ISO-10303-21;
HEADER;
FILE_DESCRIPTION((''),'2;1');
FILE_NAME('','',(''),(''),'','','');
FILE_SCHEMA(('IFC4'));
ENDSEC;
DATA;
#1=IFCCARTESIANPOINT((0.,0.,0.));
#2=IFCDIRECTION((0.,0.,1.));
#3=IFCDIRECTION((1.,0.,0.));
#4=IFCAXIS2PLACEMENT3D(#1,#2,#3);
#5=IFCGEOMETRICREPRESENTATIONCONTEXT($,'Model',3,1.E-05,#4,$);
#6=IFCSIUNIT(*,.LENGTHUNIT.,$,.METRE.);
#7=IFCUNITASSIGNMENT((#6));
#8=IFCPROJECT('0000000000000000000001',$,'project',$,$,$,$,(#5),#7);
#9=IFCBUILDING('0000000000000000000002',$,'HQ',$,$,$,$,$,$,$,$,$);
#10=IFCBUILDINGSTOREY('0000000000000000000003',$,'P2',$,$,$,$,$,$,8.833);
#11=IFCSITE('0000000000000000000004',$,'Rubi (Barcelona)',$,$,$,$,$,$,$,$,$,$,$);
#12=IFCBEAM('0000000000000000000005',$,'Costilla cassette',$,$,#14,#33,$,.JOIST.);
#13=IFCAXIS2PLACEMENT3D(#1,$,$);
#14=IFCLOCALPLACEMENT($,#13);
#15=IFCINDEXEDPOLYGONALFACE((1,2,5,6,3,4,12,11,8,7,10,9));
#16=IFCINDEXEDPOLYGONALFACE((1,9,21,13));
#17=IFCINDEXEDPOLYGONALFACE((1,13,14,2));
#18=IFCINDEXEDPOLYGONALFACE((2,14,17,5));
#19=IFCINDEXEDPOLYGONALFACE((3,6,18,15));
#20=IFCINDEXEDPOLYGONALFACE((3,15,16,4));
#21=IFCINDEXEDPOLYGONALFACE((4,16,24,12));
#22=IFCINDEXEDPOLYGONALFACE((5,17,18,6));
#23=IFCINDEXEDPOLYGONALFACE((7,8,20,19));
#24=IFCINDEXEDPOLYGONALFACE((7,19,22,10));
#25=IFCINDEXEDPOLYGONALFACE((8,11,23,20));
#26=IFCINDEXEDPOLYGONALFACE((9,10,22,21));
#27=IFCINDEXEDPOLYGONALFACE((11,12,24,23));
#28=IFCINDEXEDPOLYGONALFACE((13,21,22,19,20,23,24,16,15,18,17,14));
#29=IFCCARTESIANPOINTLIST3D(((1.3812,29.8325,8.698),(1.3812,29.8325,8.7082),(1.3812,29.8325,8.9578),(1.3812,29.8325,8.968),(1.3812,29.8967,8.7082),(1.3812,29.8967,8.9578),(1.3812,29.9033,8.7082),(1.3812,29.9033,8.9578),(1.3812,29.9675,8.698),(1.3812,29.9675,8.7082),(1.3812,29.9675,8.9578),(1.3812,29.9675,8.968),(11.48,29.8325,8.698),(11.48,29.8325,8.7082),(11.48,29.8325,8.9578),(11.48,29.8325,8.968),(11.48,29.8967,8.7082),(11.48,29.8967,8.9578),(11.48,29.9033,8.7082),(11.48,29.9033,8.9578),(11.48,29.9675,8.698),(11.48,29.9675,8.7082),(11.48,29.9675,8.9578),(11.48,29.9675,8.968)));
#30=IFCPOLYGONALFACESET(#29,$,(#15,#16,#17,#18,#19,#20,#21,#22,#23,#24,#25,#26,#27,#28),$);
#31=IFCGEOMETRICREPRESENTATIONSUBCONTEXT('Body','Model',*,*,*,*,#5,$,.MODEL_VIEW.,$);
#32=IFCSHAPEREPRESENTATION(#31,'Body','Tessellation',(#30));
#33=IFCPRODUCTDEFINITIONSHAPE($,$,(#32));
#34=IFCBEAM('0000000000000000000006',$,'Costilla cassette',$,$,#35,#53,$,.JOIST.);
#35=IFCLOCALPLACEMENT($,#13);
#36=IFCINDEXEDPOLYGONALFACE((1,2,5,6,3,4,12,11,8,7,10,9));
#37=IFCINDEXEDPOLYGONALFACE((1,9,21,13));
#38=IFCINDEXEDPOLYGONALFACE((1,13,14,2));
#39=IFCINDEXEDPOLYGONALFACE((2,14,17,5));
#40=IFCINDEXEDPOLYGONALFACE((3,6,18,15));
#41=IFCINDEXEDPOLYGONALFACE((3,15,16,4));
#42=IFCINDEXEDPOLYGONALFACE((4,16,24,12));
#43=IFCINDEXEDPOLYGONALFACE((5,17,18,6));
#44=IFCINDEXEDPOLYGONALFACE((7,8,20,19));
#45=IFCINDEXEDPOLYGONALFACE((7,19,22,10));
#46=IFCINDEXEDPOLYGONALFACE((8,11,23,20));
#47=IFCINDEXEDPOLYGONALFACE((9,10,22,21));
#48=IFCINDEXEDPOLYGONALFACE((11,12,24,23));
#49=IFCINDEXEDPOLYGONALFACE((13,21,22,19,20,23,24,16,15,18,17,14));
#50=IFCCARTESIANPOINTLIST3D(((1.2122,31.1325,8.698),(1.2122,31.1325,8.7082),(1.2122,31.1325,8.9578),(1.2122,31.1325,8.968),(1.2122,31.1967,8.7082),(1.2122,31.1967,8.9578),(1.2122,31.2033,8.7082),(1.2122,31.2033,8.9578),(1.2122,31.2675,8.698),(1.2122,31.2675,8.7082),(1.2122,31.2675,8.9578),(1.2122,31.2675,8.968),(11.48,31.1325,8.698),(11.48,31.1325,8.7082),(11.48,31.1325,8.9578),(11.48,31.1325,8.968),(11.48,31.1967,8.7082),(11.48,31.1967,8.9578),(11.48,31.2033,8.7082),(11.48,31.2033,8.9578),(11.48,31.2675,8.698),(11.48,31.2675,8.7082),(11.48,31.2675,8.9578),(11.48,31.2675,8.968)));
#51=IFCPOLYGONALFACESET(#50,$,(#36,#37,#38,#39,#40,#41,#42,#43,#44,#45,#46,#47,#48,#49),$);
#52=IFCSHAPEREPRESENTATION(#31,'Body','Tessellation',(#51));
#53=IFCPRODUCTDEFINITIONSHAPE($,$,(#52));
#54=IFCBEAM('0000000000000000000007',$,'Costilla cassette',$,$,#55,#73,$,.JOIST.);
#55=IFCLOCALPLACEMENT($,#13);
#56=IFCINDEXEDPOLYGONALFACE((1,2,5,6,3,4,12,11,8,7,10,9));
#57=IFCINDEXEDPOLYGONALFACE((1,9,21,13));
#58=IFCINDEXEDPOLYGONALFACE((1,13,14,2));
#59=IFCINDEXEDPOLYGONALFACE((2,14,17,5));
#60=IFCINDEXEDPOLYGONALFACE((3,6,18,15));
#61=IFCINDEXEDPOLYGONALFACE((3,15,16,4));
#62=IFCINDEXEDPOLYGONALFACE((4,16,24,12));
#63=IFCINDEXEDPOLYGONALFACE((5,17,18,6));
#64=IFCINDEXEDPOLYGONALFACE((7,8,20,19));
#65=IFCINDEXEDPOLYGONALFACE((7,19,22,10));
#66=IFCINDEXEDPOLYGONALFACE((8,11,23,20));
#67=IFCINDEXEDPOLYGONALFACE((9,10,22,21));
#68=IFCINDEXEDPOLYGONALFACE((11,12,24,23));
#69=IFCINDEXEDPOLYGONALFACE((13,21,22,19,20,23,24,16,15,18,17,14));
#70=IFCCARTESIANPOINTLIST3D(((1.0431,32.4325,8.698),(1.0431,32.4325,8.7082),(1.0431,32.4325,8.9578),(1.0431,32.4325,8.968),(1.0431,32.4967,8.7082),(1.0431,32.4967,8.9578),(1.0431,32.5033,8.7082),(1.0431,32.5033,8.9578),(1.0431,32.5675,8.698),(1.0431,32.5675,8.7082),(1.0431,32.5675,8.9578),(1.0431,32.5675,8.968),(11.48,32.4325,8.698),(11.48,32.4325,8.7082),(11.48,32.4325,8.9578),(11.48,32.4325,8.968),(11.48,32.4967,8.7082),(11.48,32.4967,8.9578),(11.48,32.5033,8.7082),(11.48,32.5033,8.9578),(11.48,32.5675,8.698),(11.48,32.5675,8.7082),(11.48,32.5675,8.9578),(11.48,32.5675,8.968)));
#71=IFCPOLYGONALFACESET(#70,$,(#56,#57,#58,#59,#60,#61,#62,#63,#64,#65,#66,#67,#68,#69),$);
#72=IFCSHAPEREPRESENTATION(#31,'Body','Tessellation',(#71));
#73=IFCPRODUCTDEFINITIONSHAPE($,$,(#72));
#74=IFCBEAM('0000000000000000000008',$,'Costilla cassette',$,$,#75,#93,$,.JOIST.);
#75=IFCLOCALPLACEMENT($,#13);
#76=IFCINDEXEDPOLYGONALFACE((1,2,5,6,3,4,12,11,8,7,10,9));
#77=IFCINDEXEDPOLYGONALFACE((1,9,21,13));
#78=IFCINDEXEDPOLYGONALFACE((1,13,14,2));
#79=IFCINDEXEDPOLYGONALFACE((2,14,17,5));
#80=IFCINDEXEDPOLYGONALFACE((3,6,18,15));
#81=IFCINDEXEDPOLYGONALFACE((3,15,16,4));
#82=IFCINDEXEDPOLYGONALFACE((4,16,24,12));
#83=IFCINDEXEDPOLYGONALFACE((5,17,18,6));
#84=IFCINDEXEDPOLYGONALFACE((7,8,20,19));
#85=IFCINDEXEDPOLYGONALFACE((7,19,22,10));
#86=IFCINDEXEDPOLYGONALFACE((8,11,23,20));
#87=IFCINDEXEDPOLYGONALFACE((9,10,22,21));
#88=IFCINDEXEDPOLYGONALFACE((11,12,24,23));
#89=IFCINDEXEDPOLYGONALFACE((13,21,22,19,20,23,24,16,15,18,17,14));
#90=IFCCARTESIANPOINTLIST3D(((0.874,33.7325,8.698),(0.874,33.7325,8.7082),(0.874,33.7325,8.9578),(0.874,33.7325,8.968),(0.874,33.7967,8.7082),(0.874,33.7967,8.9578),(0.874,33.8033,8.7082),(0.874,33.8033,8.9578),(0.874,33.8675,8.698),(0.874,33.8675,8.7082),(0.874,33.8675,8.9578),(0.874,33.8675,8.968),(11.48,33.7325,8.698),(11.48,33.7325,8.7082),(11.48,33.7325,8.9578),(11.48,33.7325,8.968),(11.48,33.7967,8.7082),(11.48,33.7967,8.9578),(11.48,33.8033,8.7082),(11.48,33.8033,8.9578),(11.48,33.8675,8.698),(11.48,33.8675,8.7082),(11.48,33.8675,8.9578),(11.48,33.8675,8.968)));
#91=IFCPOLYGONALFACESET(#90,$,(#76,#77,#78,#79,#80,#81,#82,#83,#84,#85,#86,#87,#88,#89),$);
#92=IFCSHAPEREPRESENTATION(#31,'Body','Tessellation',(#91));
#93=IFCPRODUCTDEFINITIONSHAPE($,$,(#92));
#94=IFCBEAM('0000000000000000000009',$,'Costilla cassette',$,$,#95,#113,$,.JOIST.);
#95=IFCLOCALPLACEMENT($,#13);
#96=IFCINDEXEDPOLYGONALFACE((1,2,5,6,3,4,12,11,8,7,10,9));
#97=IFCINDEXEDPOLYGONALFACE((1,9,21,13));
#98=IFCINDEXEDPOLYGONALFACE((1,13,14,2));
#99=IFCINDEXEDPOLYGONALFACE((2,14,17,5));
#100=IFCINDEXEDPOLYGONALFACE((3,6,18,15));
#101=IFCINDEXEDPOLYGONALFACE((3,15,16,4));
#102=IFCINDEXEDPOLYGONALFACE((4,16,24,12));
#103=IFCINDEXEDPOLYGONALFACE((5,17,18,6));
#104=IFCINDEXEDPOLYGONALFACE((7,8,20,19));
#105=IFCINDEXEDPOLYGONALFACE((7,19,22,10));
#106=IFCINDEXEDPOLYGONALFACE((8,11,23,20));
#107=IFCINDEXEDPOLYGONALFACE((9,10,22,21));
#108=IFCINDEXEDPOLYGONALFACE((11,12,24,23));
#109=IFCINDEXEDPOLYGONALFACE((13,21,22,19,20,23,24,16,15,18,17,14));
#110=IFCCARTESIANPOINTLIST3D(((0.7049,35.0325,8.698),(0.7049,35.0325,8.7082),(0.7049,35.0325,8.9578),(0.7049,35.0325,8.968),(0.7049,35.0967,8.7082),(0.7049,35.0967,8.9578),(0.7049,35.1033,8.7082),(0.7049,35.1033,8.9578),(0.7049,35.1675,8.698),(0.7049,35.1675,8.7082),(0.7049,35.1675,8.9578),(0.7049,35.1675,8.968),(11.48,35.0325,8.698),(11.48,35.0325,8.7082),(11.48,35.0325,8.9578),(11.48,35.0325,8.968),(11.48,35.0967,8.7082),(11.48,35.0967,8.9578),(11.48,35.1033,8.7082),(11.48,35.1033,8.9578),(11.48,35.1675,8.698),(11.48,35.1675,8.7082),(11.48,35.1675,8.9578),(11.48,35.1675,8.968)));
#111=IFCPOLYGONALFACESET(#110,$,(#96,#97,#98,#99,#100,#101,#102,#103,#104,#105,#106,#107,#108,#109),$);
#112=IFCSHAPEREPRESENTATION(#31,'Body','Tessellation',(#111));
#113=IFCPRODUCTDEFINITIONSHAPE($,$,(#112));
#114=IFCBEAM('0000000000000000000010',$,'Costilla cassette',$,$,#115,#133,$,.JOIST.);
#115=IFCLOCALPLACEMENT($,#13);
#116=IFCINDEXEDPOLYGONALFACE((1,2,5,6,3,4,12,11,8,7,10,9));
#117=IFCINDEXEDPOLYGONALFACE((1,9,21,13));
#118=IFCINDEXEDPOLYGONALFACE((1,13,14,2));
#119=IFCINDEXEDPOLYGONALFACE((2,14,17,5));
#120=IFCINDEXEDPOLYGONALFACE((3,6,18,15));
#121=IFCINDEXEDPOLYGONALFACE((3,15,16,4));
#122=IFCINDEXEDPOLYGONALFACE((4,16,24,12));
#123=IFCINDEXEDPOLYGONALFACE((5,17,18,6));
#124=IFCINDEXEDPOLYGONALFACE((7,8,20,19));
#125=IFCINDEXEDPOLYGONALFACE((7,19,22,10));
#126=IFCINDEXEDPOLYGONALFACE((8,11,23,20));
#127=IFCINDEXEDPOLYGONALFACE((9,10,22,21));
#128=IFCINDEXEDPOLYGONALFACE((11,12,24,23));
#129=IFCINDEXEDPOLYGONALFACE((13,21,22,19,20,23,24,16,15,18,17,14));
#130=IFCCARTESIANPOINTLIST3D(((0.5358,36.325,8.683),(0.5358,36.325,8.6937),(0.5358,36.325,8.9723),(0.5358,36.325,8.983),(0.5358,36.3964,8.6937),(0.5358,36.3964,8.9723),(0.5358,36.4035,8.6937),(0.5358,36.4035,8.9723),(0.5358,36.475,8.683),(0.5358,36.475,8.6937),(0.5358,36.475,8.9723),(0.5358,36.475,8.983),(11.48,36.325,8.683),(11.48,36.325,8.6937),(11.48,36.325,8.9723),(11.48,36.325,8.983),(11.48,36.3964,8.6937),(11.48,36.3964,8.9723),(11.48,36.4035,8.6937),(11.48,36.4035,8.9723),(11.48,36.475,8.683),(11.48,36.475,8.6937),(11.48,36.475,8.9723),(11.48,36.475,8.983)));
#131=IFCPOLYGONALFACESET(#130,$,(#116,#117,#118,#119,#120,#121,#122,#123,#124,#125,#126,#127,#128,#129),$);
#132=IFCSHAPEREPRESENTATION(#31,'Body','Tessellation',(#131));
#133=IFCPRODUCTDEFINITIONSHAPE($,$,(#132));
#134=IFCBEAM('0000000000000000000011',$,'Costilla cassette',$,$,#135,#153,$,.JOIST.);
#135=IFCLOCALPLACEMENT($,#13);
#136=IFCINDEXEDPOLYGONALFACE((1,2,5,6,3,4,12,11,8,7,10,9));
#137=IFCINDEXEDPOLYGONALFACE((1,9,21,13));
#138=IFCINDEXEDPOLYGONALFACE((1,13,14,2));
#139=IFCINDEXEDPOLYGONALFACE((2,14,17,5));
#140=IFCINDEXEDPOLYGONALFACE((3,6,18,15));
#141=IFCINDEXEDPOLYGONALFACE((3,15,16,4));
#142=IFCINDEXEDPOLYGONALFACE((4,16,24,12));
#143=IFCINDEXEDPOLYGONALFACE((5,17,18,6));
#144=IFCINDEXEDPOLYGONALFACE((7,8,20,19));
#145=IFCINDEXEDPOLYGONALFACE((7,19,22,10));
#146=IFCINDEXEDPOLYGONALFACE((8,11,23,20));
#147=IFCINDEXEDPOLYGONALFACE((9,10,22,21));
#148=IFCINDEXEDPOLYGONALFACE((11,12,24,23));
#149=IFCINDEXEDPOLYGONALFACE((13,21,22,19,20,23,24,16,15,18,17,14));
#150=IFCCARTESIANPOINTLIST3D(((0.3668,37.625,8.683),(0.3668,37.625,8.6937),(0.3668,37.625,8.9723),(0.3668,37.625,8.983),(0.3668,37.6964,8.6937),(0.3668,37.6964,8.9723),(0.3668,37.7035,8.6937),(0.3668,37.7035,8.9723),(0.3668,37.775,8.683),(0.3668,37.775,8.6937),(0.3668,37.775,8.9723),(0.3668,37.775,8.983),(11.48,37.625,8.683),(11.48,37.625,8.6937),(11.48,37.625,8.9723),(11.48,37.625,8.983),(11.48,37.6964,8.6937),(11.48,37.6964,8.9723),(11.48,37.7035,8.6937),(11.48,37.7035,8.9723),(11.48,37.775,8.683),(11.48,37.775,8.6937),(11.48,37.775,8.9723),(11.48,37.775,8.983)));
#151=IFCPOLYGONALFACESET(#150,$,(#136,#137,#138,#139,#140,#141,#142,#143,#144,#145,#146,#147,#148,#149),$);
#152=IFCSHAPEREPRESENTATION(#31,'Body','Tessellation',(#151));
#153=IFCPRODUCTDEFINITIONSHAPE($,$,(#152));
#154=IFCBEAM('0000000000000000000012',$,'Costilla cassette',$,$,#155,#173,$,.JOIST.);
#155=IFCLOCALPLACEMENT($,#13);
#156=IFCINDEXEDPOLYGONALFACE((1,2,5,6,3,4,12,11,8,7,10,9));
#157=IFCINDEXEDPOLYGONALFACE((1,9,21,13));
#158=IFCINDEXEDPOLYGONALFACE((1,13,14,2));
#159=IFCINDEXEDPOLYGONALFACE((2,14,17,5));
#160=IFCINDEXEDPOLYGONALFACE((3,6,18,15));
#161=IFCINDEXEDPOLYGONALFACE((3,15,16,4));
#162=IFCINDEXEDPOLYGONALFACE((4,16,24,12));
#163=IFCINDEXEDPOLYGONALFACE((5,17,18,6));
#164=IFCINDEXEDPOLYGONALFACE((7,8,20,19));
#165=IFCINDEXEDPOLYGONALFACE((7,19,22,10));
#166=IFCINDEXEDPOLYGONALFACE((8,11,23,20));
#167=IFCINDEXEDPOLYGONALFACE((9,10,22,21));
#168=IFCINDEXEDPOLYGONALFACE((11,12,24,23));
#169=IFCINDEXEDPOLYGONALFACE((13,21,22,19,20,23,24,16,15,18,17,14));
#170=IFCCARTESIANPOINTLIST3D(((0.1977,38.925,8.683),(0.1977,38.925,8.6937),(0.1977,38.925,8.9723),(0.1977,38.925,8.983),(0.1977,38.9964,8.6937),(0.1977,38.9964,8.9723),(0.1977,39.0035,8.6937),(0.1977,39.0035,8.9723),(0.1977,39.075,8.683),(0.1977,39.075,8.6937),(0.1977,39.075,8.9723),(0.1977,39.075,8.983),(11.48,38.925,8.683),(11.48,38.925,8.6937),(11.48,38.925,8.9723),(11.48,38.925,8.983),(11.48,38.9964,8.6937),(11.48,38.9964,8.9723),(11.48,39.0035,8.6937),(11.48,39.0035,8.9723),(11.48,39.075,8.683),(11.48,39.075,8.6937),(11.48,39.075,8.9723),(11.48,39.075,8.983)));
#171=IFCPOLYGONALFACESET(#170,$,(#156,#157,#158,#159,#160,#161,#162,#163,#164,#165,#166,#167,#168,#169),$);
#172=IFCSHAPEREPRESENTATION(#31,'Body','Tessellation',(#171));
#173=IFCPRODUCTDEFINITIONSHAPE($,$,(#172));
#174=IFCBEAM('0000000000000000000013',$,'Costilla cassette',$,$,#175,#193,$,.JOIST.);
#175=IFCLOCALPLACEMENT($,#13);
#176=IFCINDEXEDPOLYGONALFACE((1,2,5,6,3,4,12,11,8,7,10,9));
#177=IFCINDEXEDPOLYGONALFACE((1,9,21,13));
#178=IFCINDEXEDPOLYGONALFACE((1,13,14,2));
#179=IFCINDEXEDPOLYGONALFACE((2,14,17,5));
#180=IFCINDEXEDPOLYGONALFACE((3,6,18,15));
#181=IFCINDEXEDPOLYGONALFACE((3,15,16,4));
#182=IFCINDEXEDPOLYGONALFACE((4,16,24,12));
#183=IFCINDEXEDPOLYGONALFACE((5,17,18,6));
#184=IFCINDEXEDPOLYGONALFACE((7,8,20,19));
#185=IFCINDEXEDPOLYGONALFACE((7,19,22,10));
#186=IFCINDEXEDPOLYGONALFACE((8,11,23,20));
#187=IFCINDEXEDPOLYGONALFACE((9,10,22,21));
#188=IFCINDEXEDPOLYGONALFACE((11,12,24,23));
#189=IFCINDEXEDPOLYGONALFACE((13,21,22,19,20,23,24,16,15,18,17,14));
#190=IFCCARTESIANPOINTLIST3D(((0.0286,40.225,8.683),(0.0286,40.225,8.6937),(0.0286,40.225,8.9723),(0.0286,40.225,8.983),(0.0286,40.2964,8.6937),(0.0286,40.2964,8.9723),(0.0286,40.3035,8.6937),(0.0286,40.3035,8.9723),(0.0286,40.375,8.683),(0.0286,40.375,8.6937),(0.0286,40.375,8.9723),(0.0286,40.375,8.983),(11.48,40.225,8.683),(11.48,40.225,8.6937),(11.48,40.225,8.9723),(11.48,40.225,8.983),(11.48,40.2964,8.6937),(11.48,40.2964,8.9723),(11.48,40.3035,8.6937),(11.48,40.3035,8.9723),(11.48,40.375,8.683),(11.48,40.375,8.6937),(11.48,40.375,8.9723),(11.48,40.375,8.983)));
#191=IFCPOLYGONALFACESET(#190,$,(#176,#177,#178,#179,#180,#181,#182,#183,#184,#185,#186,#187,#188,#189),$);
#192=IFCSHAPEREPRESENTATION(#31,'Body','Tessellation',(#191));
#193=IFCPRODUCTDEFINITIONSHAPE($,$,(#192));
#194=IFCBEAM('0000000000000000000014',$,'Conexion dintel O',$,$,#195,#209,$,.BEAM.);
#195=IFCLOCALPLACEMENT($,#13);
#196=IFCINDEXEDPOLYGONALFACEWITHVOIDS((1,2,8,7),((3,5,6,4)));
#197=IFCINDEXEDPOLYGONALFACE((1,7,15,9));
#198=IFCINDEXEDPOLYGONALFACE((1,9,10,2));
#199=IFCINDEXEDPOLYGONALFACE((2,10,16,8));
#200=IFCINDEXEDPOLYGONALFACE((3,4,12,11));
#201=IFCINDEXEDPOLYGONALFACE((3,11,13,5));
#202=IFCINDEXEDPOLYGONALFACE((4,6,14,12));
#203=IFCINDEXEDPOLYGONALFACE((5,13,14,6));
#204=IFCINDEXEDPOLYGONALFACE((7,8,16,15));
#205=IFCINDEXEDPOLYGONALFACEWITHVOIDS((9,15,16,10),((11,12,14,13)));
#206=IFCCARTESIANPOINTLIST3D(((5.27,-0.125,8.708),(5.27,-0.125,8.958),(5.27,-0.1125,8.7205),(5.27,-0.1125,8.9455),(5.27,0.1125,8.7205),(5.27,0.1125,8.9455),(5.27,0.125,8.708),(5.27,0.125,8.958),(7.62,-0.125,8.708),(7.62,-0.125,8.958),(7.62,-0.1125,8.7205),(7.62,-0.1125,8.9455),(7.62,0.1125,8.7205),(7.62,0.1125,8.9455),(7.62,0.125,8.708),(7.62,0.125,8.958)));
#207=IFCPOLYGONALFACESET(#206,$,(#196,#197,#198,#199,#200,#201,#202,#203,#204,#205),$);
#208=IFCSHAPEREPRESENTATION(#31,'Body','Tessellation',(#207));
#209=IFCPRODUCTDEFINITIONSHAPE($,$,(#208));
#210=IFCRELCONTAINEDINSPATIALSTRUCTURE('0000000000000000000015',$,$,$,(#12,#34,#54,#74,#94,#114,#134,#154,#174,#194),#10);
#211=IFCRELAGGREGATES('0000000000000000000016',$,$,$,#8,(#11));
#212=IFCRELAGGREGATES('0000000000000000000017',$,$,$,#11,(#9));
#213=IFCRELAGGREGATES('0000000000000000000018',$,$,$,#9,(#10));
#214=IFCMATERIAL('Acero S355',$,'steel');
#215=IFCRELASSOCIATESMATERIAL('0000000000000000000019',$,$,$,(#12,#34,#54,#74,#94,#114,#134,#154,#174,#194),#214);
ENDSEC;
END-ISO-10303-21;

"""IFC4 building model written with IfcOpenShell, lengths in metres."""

from ifc_helpers import new_model, si_unit, frame, origin_with_axes, place, context, subcontext, project, spatial, hollow_rectangle, i_section, extrude, material, element, save


model = new_model("IFC4")

# Units and contexts
model_context = context("Model", 3, precision=1e-05, world=origin_with_axes())
body_context = subcontext(model_context, "Body", "Model", "MODEL_VIEW")
ifc_project = project(units=[si_unit("LENGTHUNIT", "METRE")], contexts=[model_context])

# Site, building, storey
site = spatial("IfcSite", under=ifc_project, Name="Rubi (Barcelona)")
building = spatial("IfcBuilding", under=site, Name="HQ")
storey = spatial("IfcBuildingStorey", under=building, Name="P2", Elevation=8.833)

# Beams
ifc_material_1 = material(Name="Acero S355", Category="steel")
beam_1_placement = place(None, origin_with_axes())
element("IfcBeam", 1, at=beam_1_placement, inside=storey, material=ifc_material_1, Name="Costilla cassette", PredefinedType="JOIST", context=body_context, shape_type="SweptSolid", body=[
    extrude(i_section(OverallWidth=0.135, OverallDepth=0.27, WebThickness=0.0066, FlangeThickness=0.0102), frame((1.3812, 29.9, 8.833), z_axis=(1.0, 0.0, 0.0), x_axis=(0.0, 1.0, 0.0)), (0.0, 0.0, 1.0), 10.0988),
])
beam_2_placement = place(None, origin_with_axes())
element("IfcBeam", 2, at=beam_2_placement, inside=storey, material=ifc_material_1, Name="Costilla cassette", PredefinedType="JOIST", context=body_context, shape_type="SweptSolid", body=[
    extrude(i_section(OverallWidth=0.135, OverallDepth=0.27, WebThickness=0.0066, FlangeThickness=0.0102), frame((1.2122, 31.2, 8.833), z_axis=(1.0, 0.0, 0.0), x_axis=(0.0, 1.0, 0.0)), (0.0, 0.0, 1.0), 10.2678),
])
beam_3_placement = place(None, origin_with_axes())
element("IfcBeam", 3, at=beam_3_placement, inside=storey, material=ifc_material_1, Name="Costilla cassette", PredefinedType="JOIST", context=body_context, shape_type="SweptSolid", body=[
    extrude(i_section(OverallWidth=0.135, OverallDepth=0.27, WebThickness=0.0066, FlangeThickness=0.0102), frame((1.0431, 32.5, 8.833), z_axis=(1.0, 0.0, 0.0), x_axis=(0.0, 1.0, 0.0)), (0.0, 0.0, 1.0), 10.4369),
])
beam_4_placement = place(None, origin_with_axes())
element("IfcBeam", 4, at=beam_4_placement, inside=storey, material=ifc_material_1, Name="Costilla cassette", PredefinedType="JOIST", context=body_context, shape_type="SweptSolid", body=[
    extrude(i_section(OverallWidth=0.135, OverallDepth=0.27, WebThickness=0.0066, FlangeThickness=0.0102), frame((0.874, 33.8, 8.833), z_axis=(1.0, 0.0, 0.0), x_axis=(0.0, 1.0, 0.0)), (0.0, 0.0, 1.0), 10.606),
])
beam_5_placement = place(None, origin_with_axes())
element("IfcBeam", 5, at=beam_5_placement, inside=storey, material=ifc_material_1, Name="Costilla cassette", PredefinedType="JOIST", context=body_context, shape_type="SweptSolid", body=[
    extrude(i_section(OverallWidth=0.135, OverallDepth=0.27, WebThickness=0.0066, FlangeThickness=0.0102), frame((0.7049, 35.1, 8.833), z_axis=(1.0, 0.0, 0.0), x_axis=(0.0, 1.0, 0.0)), (0.0, 0.0, 1.0), 10.7751),
])
beam_6_placement = place(None, origin_with_axes())
element("IfcBeam", 6, at=beam_6_placement, inside=storey, material=ifc_material_1, Name="Costilla cassette", PredefinedType="JOIST", context=body_context, shape_type="SweptSolid", body=[
    extrude(i_section(OverallWidth=0.15, OverallDepth=0.3, WebThickness=0.0071, FlangeThickness=0.0107), frame((0.5358, 36.4, 8.833), z_axis=(1.0, 0.0, 0.0), x_axis=(0.0, 1.0, 0.0)), (0.0, 0.0, 1.0), 10.9442),
])
beam_7_placement = place(None, origin_with_axes())
element("IfcBeam", 7, at=beam_7_placement, inside=storey, material=ifc_material_1, Name="Costilla cassette", PredefinedType="JOIST", context=body_context, shape_type="SweptSolid", body=[
    extrude(i_section(OverallWidth=0.15, OverallDepth=0.3, WebThickness=0.0071, FlangeThickness=0.0107), frame((0.3668, 37.7, 8.833), z_axis=(1.0, 0.0, 0.0), x_axis=(0.0, 1.0, 0.0)), (0.0, 0.0, 1.0), 11.1132),
])
beam_8_placement = place(None, origin_with_axes())
element("IfcBeam", 8, at=beam_8_placement, inside=storey, material=ifc_material_1, Name="Costilla cassette", PredefinedType="JOIST", context=body_context, shape_type="SweptSolid", body=[
    extrude(i_section(OverallWidth=0.15, OverallDepth=0.3, WebThickness=0.0071, FlangeThickness=0.0107), frame((0.1977, 39.0, 8.833), z_axis=(1.0, 0.0, 0.0), x_axis=(0.0, 1.0, 0.0)), (0.0, 0.0, 1.0), 11.2823),
])
beam_9_placement = place(None, origin_with_axes())
element("IfcBeam", 9, at=beam_9_placement, inside=storey, material=ifc_material_1, Name="Costilla cassette", PredefinedType="JOIST", context=body_context, shape_type="SweptSolid", body=[
    extrude(i_section(OverallWidth=0.15, OverallDepth=0.3, WebThickness=0.0071, FlangeThickness=0.0107), frame((0.0286, 40.3, 8.833), z_axis=(1.0, 0.0, 0.0), x_axis=(0.0, 1.0, 0.0)), (0.0, 0.0, 1.0), 11.4514),
])
beam_10_placement = place(None, origin_with_axes())
element("IfcBeam", 10, at=beam_10_placement, inside=storey, material=ifc_material_1, Name="Conexion dintel O", PredefinedType="BEAM", context=body_context, shape_type="SweptSolid", body=[
    extrude(hollow_rectangle(XDim=0.25, YDim=0.25, WallThickness=0.0125), frame((5.27, 0.0, 8.833), z_axis=(1.0, 0.0, 0.0), x_axis=(0.0, 1.0, 0.0)), (0.0, 0.0, 1.0), 2.35),
])

save(model, "model.ifc")
